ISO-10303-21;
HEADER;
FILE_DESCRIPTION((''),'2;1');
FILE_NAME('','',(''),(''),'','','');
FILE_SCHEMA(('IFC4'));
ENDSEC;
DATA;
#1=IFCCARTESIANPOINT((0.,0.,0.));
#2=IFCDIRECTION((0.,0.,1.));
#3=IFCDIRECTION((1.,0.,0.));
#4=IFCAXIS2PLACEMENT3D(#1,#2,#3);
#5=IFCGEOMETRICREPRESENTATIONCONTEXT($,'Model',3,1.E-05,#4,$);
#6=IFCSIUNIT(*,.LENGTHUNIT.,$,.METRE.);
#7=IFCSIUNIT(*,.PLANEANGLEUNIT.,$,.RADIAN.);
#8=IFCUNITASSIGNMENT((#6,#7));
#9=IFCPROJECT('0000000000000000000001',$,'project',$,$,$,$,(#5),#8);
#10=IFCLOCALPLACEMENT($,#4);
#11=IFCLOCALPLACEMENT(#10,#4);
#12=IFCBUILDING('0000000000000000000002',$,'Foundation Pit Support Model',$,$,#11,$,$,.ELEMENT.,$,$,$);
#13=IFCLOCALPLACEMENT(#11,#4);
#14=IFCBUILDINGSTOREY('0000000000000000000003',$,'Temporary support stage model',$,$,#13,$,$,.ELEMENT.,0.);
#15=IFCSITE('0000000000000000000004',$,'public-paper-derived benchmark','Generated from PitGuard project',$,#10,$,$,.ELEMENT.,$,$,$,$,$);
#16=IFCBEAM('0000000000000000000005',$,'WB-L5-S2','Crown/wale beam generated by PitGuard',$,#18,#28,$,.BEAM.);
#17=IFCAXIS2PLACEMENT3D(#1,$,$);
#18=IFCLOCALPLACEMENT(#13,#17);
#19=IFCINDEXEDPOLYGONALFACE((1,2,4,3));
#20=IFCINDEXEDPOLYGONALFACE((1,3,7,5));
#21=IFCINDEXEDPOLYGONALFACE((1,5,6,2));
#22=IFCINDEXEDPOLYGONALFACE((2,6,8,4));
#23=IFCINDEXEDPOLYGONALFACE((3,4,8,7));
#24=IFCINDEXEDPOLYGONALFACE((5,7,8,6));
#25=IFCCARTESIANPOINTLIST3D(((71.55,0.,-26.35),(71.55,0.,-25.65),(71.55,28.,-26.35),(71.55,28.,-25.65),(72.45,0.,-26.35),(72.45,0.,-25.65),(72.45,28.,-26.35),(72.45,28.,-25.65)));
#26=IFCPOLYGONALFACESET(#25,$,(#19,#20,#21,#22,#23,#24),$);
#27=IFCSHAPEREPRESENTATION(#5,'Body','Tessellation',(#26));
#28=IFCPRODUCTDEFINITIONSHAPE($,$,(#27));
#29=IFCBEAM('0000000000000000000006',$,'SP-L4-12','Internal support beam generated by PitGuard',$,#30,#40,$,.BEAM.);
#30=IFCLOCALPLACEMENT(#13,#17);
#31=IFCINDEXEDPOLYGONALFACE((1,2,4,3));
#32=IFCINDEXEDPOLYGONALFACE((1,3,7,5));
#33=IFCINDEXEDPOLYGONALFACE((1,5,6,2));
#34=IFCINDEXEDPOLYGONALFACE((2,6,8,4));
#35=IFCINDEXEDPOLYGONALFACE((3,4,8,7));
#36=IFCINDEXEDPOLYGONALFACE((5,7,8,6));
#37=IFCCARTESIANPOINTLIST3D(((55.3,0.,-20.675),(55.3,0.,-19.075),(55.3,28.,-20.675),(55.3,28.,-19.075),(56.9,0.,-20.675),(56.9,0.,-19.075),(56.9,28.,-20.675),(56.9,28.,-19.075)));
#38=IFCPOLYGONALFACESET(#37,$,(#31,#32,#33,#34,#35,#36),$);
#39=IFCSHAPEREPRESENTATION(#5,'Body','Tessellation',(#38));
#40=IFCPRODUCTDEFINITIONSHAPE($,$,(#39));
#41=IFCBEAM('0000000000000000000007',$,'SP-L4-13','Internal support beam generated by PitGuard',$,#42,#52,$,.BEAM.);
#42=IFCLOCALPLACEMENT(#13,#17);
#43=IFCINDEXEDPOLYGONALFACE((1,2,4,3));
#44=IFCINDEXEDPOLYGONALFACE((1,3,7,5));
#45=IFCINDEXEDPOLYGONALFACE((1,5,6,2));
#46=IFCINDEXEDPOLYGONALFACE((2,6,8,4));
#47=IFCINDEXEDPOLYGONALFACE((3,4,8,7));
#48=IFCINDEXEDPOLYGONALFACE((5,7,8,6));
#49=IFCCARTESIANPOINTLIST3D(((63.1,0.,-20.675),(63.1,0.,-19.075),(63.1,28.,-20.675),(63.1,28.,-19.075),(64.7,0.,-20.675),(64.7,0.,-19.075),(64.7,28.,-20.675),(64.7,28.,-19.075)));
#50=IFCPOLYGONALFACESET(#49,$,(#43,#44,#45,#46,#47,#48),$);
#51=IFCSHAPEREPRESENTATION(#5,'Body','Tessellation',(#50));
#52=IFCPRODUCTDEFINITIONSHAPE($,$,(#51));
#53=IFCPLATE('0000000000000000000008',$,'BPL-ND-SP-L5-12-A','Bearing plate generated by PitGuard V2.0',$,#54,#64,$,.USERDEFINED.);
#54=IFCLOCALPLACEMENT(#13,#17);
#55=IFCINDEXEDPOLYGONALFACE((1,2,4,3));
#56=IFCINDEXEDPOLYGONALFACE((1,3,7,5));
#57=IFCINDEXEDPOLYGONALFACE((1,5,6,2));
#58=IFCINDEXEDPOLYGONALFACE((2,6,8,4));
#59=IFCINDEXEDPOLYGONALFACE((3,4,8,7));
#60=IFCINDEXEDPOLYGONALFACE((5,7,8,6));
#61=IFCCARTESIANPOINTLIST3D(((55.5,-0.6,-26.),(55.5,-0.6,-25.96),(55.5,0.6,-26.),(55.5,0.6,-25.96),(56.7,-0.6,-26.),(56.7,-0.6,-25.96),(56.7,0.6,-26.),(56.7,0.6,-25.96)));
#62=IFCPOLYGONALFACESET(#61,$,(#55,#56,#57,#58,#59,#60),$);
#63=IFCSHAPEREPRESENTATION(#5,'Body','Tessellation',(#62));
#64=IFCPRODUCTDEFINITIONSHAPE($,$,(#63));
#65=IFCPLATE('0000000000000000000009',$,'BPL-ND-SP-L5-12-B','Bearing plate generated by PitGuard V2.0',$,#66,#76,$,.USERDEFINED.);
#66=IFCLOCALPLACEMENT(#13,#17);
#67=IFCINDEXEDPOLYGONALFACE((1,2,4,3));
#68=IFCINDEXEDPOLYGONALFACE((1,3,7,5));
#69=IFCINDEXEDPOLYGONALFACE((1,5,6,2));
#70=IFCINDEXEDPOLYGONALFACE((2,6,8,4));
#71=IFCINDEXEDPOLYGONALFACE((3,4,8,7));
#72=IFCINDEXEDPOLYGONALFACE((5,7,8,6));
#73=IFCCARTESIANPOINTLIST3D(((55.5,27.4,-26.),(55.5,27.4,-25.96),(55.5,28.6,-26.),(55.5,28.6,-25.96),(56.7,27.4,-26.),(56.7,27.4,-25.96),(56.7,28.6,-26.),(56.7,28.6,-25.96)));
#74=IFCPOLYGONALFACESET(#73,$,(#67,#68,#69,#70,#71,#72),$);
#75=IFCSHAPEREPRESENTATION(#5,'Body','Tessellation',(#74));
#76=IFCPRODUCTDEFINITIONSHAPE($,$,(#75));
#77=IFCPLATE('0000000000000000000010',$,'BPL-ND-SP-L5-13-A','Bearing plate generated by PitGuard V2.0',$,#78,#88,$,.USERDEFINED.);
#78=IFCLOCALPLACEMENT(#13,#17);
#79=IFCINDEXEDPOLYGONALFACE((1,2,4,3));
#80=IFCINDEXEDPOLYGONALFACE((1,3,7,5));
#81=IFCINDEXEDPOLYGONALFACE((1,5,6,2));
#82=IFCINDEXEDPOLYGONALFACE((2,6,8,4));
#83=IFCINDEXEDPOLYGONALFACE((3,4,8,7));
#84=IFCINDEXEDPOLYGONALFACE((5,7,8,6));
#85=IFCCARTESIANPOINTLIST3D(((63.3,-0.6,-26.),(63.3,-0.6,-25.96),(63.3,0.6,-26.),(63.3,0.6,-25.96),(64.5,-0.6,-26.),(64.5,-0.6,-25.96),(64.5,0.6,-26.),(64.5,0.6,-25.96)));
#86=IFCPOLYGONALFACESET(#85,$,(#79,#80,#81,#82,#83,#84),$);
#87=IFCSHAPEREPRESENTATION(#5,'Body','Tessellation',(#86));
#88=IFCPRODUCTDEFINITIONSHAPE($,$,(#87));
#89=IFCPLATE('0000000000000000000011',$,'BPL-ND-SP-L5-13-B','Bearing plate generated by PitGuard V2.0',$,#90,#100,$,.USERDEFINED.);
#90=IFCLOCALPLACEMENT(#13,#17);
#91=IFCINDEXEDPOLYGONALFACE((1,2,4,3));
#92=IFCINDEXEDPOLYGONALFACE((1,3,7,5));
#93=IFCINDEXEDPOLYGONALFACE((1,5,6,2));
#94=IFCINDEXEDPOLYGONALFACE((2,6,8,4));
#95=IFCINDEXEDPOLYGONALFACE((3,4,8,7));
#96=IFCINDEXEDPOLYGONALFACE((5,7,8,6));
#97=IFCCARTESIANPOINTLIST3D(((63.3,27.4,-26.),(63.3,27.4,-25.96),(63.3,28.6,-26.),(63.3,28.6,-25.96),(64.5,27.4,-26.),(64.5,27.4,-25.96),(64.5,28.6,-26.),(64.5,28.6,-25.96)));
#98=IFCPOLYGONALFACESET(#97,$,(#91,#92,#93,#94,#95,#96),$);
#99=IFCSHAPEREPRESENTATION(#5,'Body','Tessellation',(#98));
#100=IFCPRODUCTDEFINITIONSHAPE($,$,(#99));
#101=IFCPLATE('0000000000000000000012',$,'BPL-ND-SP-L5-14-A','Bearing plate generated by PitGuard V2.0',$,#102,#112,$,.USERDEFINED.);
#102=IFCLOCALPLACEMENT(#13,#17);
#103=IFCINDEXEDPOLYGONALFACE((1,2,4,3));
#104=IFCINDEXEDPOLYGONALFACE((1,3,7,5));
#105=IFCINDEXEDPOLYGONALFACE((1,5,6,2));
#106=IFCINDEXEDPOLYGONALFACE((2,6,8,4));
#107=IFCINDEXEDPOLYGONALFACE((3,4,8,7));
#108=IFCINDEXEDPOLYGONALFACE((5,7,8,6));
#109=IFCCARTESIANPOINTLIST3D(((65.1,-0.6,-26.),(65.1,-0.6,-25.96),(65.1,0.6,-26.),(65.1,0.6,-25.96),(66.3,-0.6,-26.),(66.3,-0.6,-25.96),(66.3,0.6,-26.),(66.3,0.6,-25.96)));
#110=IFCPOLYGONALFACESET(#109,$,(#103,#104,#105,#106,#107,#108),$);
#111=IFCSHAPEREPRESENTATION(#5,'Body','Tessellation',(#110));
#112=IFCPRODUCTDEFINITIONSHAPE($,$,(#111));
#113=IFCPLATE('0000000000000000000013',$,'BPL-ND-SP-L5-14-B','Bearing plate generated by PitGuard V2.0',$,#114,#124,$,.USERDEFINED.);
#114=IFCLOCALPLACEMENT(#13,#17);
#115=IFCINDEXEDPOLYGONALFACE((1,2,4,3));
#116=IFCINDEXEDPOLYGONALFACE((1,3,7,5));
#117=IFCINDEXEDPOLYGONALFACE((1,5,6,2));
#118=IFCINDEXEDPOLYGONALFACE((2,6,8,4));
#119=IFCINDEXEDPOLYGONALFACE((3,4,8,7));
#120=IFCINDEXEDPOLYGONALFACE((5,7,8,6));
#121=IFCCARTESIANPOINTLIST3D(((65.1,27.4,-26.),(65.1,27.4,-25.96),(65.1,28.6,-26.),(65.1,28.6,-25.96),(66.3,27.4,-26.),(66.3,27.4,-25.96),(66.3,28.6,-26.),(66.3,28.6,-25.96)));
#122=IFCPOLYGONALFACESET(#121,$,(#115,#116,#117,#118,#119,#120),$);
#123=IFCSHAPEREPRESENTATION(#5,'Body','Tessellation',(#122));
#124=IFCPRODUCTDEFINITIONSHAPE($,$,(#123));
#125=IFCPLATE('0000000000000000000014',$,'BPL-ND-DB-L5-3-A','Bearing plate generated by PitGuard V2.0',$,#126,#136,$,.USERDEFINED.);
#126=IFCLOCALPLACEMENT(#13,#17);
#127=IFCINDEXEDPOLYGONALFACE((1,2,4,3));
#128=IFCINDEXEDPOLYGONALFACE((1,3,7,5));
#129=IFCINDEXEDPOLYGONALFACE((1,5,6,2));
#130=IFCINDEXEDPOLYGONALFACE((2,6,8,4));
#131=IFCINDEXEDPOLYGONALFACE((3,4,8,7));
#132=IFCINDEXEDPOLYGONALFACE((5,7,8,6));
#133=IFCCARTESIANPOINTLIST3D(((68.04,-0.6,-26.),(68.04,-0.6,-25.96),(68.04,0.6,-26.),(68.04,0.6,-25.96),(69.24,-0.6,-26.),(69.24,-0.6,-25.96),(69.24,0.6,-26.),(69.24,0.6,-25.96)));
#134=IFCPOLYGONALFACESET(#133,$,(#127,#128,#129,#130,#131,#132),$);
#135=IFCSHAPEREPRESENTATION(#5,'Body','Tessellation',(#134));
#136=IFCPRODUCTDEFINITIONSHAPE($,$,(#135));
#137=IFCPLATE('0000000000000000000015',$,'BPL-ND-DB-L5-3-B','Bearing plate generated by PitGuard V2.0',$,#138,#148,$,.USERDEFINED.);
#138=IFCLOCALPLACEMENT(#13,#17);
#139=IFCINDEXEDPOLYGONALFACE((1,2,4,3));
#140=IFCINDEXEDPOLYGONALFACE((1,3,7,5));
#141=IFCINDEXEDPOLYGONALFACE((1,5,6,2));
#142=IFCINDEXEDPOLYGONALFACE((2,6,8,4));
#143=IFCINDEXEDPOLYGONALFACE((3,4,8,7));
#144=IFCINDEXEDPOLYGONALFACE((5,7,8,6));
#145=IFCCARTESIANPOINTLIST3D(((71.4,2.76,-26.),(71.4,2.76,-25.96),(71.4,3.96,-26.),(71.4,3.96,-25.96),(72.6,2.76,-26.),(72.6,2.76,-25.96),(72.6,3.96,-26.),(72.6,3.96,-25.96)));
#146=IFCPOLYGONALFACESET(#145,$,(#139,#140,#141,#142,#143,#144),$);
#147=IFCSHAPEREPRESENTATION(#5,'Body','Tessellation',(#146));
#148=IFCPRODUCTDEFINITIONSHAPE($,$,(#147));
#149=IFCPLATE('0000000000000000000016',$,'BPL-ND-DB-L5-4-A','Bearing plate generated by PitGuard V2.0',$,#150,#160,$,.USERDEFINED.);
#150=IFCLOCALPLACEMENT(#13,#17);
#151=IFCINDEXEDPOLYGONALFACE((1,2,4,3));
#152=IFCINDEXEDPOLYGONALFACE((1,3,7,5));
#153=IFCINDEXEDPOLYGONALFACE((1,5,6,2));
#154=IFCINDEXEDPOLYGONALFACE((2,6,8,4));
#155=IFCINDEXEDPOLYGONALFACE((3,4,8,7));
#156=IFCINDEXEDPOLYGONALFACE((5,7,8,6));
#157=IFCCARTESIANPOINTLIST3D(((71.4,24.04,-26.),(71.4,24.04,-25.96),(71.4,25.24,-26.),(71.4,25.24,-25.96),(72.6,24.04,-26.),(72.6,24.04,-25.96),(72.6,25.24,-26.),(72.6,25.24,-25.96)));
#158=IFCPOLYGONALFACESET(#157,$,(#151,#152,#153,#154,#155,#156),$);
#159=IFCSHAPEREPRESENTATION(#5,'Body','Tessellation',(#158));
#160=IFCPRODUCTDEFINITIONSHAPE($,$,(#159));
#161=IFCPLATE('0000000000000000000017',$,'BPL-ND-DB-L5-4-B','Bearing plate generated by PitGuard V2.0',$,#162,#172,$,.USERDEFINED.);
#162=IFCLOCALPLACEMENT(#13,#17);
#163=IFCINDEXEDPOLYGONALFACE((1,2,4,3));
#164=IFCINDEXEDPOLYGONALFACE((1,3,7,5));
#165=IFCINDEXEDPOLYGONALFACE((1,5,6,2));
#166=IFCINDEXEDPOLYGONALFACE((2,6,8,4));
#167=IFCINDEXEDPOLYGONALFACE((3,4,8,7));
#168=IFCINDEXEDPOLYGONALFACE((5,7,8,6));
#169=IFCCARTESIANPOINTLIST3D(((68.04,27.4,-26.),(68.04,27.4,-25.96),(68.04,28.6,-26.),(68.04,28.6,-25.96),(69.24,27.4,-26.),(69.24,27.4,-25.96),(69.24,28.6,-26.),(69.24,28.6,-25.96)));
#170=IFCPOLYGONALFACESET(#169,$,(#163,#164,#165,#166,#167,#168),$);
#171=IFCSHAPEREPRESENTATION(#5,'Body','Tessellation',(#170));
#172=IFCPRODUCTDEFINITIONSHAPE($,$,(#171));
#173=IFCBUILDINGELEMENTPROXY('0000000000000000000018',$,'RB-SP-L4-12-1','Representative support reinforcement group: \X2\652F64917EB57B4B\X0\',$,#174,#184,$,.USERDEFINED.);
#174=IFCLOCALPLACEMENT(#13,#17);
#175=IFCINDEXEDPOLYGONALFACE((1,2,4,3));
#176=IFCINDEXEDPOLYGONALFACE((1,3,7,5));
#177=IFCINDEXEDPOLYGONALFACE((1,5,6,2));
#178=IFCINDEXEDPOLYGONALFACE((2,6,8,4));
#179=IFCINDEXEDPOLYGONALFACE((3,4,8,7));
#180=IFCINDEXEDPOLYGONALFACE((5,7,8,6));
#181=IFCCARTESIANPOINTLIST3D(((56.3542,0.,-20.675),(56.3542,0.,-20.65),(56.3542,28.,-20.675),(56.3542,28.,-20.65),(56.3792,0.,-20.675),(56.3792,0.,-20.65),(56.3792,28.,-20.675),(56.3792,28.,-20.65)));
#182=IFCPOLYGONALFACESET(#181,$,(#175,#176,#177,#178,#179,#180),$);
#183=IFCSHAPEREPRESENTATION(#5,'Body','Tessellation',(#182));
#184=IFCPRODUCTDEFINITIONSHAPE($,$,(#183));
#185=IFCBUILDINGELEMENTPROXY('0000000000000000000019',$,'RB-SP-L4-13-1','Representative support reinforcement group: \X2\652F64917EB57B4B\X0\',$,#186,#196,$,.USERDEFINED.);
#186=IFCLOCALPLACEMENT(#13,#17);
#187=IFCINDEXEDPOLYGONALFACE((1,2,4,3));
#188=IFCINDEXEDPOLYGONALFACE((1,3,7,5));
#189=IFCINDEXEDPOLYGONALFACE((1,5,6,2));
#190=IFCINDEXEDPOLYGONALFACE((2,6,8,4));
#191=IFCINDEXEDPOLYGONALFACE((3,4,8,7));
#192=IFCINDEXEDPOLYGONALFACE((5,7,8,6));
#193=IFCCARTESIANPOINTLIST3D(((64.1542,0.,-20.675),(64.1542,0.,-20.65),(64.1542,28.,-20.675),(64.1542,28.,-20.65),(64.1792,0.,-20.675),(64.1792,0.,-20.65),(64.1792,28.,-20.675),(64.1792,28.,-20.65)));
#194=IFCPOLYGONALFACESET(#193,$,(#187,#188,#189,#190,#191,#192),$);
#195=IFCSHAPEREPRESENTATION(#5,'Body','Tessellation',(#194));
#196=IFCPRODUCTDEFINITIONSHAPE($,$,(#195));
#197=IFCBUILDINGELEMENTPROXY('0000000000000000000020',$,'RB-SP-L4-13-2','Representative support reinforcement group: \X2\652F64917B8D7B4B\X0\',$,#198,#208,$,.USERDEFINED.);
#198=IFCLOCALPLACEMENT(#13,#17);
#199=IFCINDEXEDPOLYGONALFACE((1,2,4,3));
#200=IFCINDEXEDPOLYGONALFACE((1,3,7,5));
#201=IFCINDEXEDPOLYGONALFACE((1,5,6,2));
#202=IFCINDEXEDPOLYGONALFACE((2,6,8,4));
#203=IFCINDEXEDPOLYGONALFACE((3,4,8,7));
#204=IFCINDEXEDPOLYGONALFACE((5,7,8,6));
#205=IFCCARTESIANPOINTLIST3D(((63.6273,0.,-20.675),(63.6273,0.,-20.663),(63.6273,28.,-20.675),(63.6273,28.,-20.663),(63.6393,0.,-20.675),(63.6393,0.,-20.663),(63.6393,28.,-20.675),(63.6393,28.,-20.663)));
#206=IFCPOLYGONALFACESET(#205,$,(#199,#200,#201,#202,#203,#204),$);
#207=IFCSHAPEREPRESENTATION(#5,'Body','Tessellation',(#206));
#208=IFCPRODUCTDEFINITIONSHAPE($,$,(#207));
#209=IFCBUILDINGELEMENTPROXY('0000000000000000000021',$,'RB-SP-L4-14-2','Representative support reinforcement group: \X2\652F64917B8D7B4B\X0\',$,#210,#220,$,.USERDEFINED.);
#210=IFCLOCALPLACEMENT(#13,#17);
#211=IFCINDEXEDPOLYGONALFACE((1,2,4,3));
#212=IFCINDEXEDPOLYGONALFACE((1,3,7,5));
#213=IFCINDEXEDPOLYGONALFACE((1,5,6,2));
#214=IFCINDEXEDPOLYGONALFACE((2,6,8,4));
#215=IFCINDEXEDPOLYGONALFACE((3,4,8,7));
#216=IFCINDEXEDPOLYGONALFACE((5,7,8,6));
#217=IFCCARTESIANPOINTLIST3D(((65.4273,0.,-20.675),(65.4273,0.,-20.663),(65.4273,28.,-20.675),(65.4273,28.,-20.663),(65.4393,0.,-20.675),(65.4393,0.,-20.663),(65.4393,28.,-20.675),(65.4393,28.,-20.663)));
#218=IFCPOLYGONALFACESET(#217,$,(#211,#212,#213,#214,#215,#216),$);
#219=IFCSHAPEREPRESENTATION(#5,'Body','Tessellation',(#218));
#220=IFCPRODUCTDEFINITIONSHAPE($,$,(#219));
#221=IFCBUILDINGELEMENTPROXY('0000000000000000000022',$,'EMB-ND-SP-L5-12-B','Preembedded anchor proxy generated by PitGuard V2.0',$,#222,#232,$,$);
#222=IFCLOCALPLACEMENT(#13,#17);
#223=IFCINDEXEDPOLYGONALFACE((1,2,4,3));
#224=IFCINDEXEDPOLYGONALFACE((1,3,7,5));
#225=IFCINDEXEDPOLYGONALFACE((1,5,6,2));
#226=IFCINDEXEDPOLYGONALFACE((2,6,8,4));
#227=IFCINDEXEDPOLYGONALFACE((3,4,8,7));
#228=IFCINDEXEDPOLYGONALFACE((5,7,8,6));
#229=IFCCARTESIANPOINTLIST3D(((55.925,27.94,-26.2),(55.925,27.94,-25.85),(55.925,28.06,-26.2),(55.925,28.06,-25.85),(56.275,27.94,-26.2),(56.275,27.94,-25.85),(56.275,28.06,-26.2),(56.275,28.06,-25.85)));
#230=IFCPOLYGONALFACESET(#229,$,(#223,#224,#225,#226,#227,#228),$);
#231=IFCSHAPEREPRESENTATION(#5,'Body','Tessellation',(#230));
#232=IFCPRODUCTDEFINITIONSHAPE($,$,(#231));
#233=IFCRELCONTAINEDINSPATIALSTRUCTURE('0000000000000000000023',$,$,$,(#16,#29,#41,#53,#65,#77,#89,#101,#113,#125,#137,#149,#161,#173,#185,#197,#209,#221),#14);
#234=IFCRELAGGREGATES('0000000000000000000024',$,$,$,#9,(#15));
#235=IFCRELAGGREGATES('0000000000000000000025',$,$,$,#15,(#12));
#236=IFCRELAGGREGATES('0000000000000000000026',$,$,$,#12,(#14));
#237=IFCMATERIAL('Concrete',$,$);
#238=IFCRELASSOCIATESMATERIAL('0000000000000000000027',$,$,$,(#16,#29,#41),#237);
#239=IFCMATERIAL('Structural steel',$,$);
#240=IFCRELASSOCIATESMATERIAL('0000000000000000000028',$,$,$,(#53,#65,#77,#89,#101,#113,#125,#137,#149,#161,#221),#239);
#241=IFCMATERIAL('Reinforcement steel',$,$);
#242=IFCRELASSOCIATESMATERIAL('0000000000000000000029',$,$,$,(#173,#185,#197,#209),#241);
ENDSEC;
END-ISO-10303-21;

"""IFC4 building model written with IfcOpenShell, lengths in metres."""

from ifc_helpers import new_model, si_unit, frame, origin_with_axes, origin_2d, place, context, project, spatial, rectangle, extrude, material, element, save


model = new_model("IFC4")

# Units and contexts
model_context = context("Model", 3, precision=1e-05, world=origin_with_axes())
ifc_project = project(units=[si_unit("LENGTHUNIT", "METRE"), si_unit("PLANEANGLEUNIT", "RADIAN")], contexts=[model_context])

# Site, building, storey
site_placement = place(None, origin_with_axes())
site = spatial("IfcSite", under=ifc_project, at=site_placement, Name="public-paper-derived benchmark", Description="Generated from PitGuard project", CompositionType="ELEMENT")
building_placement = place(site_placement, origin_with_axes())
building = spatial("IfcBuilding", under=site, at=building_placement, Name="Foundation Pit Support Model", CompositionType="ELEMENT")
storey_placement = place(building_placement, origin_with_axes())
storey = spatial("IfcBuildingStorey", under=building, at=storey_placement, Name="Temporary support stage model", CompositionType="ELEMENT", Elevation=0.0)

# Beams
ifc_material_1 = material(Name="Concrete")
beam_placement = place(storey_placement, frame((72.0, 14.0, -26.35), z_axis=(0.0, 0.0, 1.0), x_axis=(0.0, 1.0, 0.0)))
element("IfcBeam", 1, at=beam_placement, inside=storey, material=ifc_material_1, Name="WB-L5-S2", Description="Crown/wale beam generated by PitGuard", PredefinedType="BEAM", context=model_context, shape_type="SweptSolid", body=[
    extrude(rectangle(XDim=28.0, YDim=0.9, at=origin_2d()), origin_with_axes(), (0.0, 0.0, 1.0), 0.7),
])
for number, where, z_axis, x_axis, name in (
    (2, (56.1, 14.0, -20.675), (0.0, 0.0, 1.0), (0.0, 1.0, 0.0), "SP-L4-12"),
    (3, (63.9, 14.0, -20.675), (0.0, 0.0, 1.0), (0.0, 1.0, 0.0), "SP-L4-13"),
):
    element("IfcBeam", number, at=place(storey_placement, frame(where, z_axis=z_axis, x_axis=x_axis)), inside=storey, material=ifc_material_1, Name=name, Description="Internal support beam generated by PitGuard", PredefinedType="BEAM", context=model_context, shape_type="SweptSolid", body=[
        extrude(rectangle(XDim=28.0, YDim=1.6, at=origin_2d()), origin_with_axes(), (0.0, 0.0, 1.0), 1.6),
    ])

# Plates
ifc_material_2 = material(Name="Structural steel")
for number, where, z_axis, x_axis, name in (
    (4, (56.1, 0.0, -26.0), (0.0, 0.0, 1.0), (1.0, 0.0, 0.0), "BPL-ND-SP-L5-12-A"),
    (5, (56.1, 28.0, -26.0), (0.0, 0.0, 1.0), (1.0, 0.0, 0.0), "BPL-ND-SP-L5-12-B"),
    (6, (63.9, 0.0, -26.0), (0.0, 0.0, 1.0), (1.0, 0.0, 0.0), "BPL-ND-SP-L5-13-A"),
    (7, (63.9, 28.0, -26.0), (0.0, 0.0, 1.0), (1.0, 0.0, 0.0), "BPL-ND-SP-L5-13-B"),
    (8, (65.7, 0.0, -26.0), (0.0, 0.0, 1.0), (1.0, 0.0, 0.0), "BPL-ND-SP-L5-14-A"),
    (9, (65.7, 28.0, -26.0), (0.0, 0.0, 1.0), (1.0, 0.0, 0.0), "BPL-ND-SP-L5-14-B"),
    (10, (68.64, 0.0, -26.0), (0.0, 0.0, 1.0), (1.0, 0.0, 0.0), "BPL-ND-DB-L5-3-A"),
    (11, (72.0, 3.36, -26.0), (0.0, 0.0, 1.0), (1.0, 0.0, 0.0), "BPL-ND-DB-L5-3-B"),
    (12, (72.0, 24.64, -26.0), (0.0, 0.0, 1.0), (1.0, 0.0, 0.0), "BPL-ND-DB-L5-4-A"),
    (13, (68.64, 28.0, -26.0), (0.0, 0.0, 1.0), (1.0, 0.0, 0.0), "BPL-ND-DB-L5-4-B"),
):
    element("IfcPlate", number, at=place(storey_placement, frame(where, z_axis=z_axis, x_axis=x_axis)), inside=storey, material=ifc_material_2, Name=name, Description="Bearing plate generated by PitGuard V2.0", PredefinedType="USERDEFINED", context=model_context, shape_type="SweptSolid", body=[
        extrude(rectangle(XDim=1.2, YDim=1.2, at=origin_2d()), origin_with_axes(), (0.0, 0.0, 1.0), 0.04),
    ])

# Building element proxies
ifc_material_3 = material(Name="Reinforcement steel")
for number, where, z_axis, x_axis, name in (
    (14, (56.3667, 14.0, -20.675), (0.0, 0.0, 1.0), (0.0, 1.0, 0.0), "RB-SP-L4-12-1"),
    (15, (64.1667, 14.0, -20.675), (0.0, 0.0, 1.0), (0.0, 1.0, 0.0), "RB-SP-L4-13-1"),
):
    element("IfcBuildingElementProxy", number, at=place(storey_placement, frame(where, z_axis=z_axis, x_axis=x_axis)), inside=storey, material=ifc_material_3, Name=name, Description="Representative support reinforcement group: 支撑纵筋", PredefinedType="USERDEFINED", context=model_context, shape_type="SweptSolid", body=[
        extrude(rectangle(XDim=28.0, YDim=0.025, at=origin_2d()), origin_with_axes(), (0.0, 0.0, 1.0), 0.025),
    ])
for number, where, z_axis, x_axis, name in (
    (16, (63.6333, 14.0, -20.675), (0.0, 0.0, 1.0), (0.0, 1.0, 0.0), "RB-SP-L4-13-2"),
    (17, (65.4333, 14.0, -20.675), (0.0, 0.0, 1.0), (0.0, 1.0, 0.0), "RB-SP-L4-14-2"),
):
    element("IfcBuildingElementProxy", number, at=place(storey_placement, frame(where, z_axis=z_axis, x_axis=x_axis)), inside=storey, material=ifc_material_3, Name=name, Description="Representative support reinforcement group: 支撑箍筋", PredefinedType="USERDEFINED", context=model_context, shape_type="SweptSolid", body=[
        extrude(rectangle(XDim=28.0, YDim=0.012, at=origin_2d()), origin_with_axes(), (0.0, 0.0, 1.0), 0.012),
    ])
for number, where, z_axis, x_axis, name in (
    (18, (56.1, 28.0, -26.2), (0.0, 0.0, 1.0), (1.0, 0.0, 0.0), "EMB-ND-SP-L5-12-B"),
):
    element("IfcBuildingElementProxy", number, at=place(storey_placement, frame(where, z_axis=z_axis, x_axis=x_axis)), inside=storey, material=ifc_material_2, Name=name, Description="Preembedded anchor proxy generated by PitGuard V2.0", context=model_context, shape_type="SweptSolid", body=[
        extrude(rectangle(XDim=0.35, YDim=0.12, at=origin_2d()), origin_with_axes(), (0.0, 0.0, 1.0), 0.35),
    ])

save(model, "model.ifc")
